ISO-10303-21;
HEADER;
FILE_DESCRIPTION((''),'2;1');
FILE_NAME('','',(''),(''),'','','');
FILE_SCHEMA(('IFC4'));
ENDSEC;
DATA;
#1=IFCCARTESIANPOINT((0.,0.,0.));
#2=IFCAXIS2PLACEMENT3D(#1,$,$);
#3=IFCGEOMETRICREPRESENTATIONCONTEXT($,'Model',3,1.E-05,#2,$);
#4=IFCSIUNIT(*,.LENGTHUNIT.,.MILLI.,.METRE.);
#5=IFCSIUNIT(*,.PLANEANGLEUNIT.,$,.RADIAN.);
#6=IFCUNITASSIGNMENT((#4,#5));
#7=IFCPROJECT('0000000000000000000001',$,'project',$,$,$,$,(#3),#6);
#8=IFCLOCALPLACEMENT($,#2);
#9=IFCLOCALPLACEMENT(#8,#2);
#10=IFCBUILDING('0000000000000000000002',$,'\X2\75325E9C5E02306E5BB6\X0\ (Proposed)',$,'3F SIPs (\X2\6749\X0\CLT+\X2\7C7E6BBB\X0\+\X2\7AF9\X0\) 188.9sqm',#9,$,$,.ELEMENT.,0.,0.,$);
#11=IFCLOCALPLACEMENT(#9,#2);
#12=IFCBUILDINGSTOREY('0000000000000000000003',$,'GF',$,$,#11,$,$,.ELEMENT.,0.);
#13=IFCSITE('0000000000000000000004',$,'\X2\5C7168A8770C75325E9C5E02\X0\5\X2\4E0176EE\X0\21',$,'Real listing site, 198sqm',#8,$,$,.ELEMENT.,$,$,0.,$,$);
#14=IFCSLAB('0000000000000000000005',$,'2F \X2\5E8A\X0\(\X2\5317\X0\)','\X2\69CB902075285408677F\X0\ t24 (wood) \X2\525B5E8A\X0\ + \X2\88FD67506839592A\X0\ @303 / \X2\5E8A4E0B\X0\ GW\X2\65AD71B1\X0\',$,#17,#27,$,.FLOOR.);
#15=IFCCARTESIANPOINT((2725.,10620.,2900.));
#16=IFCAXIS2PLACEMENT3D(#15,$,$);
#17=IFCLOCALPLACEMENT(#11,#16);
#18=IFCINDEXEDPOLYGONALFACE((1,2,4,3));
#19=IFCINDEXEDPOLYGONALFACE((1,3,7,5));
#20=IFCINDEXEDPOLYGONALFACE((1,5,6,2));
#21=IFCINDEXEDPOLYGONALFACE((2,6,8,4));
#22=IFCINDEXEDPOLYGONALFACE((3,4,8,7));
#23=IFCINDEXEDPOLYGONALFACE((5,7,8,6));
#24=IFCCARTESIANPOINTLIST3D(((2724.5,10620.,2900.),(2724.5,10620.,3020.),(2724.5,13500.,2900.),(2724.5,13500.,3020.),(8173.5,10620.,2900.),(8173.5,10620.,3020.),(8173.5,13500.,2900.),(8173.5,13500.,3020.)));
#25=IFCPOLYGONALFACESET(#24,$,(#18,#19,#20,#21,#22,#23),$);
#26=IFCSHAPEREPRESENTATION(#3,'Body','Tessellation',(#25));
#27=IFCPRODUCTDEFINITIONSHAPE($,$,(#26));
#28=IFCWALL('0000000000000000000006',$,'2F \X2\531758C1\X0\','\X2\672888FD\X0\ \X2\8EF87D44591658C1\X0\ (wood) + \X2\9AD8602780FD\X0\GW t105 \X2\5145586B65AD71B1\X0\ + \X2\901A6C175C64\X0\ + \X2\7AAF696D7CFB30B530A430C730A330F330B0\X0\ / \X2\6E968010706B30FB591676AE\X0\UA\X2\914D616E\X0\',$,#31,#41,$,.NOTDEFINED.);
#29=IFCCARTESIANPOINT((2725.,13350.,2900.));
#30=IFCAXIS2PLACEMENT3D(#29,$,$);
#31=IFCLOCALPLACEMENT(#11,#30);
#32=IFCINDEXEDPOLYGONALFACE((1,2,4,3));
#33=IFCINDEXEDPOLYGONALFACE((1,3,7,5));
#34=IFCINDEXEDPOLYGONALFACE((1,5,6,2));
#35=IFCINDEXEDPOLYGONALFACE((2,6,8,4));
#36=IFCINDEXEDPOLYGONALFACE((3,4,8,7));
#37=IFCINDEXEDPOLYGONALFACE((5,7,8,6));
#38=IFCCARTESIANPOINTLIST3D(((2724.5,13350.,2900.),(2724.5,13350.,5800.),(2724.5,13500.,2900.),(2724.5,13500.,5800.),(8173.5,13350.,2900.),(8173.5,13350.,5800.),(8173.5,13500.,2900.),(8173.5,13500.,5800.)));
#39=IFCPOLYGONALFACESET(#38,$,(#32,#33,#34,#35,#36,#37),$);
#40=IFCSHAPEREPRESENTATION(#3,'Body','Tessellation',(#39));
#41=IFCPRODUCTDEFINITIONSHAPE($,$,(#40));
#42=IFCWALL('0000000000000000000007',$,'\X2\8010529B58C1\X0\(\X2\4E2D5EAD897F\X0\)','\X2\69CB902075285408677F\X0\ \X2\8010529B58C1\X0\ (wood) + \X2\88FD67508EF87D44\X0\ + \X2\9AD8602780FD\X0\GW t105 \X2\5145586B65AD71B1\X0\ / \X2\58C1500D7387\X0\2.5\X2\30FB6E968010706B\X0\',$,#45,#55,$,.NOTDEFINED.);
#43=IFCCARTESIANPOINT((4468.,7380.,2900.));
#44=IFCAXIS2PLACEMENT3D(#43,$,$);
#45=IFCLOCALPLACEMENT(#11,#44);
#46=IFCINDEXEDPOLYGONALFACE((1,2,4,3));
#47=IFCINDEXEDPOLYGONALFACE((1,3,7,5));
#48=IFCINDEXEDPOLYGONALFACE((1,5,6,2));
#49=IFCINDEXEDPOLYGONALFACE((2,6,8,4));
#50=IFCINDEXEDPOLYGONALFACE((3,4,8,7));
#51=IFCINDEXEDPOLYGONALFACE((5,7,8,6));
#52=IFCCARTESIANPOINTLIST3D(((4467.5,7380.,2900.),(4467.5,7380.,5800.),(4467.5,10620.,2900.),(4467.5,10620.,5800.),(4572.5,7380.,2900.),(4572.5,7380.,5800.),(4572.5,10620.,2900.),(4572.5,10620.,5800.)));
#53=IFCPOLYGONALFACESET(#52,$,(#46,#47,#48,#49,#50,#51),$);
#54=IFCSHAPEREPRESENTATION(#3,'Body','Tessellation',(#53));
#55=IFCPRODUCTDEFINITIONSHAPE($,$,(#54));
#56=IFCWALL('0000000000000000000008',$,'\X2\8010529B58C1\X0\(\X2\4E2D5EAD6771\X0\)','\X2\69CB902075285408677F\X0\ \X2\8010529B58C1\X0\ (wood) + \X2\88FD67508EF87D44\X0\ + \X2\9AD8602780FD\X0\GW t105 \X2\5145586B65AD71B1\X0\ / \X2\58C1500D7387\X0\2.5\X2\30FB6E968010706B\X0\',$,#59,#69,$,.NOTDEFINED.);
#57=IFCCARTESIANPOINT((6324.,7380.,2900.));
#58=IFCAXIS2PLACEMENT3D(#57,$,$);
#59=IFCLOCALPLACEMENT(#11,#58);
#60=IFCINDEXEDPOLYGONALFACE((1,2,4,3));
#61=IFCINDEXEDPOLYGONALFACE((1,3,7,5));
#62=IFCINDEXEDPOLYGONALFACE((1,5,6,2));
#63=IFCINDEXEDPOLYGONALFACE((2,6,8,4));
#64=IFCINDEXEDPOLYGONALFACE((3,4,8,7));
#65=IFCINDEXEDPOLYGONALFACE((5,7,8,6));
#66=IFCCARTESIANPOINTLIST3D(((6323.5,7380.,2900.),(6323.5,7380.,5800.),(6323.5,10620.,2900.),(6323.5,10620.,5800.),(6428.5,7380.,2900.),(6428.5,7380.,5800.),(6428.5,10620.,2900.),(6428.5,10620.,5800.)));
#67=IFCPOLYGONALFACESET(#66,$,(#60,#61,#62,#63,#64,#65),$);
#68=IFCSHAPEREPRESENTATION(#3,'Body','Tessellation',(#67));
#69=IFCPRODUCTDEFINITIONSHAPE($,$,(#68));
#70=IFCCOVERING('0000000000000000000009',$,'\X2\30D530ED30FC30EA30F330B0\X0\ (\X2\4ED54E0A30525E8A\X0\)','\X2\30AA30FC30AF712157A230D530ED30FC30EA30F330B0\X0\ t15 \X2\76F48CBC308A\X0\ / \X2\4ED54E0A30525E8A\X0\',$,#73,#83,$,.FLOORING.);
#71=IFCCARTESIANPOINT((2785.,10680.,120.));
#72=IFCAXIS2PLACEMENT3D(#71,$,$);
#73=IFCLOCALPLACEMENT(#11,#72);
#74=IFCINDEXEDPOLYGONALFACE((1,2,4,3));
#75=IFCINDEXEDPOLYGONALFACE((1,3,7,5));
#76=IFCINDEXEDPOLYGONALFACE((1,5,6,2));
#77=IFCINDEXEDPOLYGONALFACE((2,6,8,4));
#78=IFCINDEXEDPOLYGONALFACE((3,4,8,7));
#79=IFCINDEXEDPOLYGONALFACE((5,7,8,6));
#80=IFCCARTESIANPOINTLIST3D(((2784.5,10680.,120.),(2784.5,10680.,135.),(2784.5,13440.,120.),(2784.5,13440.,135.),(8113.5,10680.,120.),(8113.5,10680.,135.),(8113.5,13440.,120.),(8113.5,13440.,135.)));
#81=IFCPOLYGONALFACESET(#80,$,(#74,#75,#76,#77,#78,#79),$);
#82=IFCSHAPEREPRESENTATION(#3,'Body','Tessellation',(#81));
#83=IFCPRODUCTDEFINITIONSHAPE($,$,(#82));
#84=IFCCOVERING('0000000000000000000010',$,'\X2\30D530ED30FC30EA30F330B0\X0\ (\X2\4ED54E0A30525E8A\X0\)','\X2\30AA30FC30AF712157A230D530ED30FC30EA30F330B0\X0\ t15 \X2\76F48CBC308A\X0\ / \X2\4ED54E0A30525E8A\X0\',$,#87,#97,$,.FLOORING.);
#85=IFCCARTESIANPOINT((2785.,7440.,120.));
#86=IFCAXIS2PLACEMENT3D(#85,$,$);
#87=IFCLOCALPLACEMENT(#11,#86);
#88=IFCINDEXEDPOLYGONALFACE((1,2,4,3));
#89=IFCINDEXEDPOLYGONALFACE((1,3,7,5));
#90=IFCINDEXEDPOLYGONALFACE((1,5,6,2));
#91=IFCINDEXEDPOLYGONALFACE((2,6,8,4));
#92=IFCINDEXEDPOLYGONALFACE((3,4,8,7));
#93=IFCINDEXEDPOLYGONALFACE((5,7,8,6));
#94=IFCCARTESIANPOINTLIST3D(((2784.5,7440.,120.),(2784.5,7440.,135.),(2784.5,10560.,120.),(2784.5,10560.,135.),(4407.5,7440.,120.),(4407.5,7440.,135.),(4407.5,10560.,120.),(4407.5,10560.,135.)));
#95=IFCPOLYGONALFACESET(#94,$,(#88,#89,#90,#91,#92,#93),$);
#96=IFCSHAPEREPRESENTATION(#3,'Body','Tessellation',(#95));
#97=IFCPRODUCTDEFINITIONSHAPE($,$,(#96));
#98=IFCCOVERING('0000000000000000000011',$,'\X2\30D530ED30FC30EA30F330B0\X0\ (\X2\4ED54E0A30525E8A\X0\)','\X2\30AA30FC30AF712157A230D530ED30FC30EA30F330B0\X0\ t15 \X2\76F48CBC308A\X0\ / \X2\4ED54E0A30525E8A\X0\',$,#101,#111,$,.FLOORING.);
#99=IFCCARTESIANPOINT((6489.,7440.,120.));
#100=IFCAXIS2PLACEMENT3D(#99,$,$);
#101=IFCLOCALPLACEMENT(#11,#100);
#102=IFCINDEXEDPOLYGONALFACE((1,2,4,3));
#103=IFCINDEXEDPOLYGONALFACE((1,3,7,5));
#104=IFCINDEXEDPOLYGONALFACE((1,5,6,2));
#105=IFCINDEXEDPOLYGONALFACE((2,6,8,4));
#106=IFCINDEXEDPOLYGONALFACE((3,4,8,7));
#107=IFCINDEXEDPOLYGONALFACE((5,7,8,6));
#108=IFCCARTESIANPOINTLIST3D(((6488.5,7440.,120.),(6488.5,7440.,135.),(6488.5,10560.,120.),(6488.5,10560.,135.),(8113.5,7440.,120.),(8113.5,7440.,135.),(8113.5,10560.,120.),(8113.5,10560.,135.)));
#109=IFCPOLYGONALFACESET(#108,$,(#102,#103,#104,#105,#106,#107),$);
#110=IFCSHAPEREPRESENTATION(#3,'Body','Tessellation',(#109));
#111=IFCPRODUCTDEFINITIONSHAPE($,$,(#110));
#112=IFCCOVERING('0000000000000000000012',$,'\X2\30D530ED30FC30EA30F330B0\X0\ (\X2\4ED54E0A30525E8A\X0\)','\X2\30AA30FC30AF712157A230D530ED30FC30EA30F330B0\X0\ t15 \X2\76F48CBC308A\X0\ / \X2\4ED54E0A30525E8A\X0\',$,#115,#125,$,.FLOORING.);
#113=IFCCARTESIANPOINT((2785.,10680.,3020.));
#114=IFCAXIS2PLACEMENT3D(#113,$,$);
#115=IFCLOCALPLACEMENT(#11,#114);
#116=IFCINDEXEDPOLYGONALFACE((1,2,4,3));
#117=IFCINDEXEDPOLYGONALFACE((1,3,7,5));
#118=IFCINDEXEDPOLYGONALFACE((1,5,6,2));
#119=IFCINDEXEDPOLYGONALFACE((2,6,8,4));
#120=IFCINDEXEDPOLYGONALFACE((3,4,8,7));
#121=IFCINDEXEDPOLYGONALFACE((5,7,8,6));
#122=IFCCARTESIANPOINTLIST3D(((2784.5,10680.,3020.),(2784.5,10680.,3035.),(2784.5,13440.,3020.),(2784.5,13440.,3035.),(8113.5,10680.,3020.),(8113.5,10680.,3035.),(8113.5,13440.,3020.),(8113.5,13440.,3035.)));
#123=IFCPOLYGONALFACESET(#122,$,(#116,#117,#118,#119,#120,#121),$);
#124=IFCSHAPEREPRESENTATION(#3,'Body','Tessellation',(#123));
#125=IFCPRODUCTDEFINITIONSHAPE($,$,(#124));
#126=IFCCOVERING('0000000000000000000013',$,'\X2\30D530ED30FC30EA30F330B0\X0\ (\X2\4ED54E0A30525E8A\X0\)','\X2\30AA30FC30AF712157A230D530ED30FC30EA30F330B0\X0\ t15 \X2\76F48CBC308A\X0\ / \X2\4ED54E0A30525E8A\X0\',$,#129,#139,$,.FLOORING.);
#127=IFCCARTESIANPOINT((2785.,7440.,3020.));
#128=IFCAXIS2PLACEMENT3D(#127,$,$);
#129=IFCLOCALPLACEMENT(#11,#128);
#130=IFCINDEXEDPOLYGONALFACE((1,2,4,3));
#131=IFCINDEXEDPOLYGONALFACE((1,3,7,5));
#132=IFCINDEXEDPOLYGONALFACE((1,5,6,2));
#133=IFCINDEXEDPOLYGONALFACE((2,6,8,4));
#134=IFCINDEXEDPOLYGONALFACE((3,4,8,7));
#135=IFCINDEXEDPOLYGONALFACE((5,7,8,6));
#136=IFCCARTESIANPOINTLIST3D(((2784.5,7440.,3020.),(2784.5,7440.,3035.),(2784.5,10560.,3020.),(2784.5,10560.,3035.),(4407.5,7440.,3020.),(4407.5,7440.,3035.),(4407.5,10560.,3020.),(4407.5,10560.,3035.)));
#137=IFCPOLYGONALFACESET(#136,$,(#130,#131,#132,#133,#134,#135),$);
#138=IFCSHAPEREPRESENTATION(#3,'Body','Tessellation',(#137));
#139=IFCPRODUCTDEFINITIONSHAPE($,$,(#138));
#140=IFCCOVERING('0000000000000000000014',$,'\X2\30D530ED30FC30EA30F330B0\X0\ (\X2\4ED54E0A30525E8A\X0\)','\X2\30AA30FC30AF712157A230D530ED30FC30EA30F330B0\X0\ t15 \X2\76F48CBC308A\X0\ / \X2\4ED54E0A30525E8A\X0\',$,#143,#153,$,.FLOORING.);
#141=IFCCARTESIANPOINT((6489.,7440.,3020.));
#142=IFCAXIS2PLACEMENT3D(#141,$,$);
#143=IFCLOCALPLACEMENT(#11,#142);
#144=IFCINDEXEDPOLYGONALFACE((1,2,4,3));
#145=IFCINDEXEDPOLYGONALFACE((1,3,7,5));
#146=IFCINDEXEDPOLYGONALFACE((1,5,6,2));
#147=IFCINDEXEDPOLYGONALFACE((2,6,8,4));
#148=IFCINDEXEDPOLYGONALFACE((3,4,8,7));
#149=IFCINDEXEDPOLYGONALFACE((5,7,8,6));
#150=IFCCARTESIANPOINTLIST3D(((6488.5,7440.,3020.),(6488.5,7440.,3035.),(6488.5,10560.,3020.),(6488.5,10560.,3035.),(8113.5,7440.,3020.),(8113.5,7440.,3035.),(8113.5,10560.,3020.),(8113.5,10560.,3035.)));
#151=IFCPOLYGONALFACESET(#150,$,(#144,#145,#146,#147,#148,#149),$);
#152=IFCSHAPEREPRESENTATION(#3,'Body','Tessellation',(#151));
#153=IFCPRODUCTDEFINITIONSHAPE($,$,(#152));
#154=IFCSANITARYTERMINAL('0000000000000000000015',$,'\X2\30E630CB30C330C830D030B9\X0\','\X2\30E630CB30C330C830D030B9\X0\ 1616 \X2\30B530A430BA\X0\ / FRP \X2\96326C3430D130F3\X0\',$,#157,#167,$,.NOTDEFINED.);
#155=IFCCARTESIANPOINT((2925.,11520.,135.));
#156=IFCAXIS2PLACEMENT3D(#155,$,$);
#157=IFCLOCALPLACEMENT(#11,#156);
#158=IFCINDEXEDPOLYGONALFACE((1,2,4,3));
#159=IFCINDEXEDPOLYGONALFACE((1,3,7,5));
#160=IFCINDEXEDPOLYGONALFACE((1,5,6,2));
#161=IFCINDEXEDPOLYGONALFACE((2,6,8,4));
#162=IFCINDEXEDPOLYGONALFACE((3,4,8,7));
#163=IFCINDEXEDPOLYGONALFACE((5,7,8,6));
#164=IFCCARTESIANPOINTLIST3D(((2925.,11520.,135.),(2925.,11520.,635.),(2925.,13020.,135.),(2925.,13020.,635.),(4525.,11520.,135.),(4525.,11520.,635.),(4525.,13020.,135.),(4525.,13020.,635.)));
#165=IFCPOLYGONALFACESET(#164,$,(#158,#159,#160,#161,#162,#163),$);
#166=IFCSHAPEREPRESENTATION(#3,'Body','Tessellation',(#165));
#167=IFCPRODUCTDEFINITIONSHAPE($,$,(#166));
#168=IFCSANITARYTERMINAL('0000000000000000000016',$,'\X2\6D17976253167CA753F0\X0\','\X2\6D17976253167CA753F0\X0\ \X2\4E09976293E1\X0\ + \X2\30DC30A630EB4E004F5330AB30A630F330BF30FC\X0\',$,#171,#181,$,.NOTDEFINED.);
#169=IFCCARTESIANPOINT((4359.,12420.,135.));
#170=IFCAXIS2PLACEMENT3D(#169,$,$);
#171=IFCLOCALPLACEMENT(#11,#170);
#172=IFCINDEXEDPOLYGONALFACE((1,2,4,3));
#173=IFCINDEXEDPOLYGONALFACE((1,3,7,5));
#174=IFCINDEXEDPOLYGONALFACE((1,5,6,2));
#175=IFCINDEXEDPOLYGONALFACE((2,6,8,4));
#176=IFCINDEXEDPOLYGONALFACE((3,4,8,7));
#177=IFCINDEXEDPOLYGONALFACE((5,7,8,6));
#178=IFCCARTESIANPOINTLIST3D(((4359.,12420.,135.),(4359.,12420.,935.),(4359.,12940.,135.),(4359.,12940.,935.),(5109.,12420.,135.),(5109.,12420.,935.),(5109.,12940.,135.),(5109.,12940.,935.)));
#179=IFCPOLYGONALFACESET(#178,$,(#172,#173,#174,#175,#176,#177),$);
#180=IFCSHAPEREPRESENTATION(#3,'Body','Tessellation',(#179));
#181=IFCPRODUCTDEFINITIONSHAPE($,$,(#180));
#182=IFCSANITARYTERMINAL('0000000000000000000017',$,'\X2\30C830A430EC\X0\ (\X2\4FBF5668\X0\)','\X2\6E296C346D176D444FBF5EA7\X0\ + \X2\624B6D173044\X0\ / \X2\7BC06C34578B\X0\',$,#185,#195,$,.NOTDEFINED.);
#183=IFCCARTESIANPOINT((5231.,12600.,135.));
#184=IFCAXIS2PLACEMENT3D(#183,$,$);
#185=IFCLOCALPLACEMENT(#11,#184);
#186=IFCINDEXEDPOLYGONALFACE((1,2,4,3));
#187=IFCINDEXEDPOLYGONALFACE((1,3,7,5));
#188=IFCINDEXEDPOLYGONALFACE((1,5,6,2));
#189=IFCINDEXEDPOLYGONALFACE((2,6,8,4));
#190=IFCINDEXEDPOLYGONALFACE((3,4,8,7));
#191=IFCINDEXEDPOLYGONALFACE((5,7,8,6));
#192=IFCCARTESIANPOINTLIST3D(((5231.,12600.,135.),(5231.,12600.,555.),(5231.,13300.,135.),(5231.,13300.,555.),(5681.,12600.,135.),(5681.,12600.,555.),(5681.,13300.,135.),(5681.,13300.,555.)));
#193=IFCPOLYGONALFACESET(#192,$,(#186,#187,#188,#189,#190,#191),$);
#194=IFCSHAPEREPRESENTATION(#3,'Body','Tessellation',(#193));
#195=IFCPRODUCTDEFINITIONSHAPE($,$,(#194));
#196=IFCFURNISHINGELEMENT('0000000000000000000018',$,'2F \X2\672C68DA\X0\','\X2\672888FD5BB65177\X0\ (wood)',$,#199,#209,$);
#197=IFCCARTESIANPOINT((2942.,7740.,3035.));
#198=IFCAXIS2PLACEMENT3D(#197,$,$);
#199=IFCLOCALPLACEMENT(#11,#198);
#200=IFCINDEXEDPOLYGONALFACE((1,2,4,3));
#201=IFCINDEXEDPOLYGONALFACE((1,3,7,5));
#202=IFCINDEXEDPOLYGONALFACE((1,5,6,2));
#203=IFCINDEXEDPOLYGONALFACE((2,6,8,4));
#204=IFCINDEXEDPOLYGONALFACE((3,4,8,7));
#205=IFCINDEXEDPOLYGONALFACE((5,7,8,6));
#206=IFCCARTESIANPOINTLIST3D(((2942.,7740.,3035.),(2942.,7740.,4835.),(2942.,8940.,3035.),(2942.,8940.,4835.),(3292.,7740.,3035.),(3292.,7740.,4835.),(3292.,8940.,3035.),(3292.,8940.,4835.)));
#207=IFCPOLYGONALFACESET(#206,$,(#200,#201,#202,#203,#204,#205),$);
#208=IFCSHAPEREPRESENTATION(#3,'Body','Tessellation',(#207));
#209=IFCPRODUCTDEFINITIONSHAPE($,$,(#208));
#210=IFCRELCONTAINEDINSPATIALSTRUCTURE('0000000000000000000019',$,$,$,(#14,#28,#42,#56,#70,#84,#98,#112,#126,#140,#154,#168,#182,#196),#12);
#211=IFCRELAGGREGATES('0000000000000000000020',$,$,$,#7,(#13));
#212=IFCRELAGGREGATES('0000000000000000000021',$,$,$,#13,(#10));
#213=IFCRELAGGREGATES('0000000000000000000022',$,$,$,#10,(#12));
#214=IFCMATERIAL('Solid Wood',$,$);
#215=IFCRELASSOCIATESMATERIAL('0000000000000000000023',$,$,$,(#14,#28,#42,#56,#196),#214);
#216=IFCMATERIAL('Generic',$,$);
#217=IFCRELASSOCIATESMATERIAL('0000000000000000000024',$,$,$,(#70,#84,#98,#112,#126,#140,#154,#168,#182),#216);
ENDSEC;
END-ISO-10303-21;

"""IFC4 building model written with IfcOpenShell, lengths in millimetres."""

from ifc_helpers import new_model, si_unit, frame, frame_2d, origin, place, context, project, spatial, rectangle, extrude, material, element, save


model = new_model("IFC4")

# Units and contexts
model_context = context("Model", 3, precision=1e-05, world=origin())
ifc_project = project(units=[si_unit("LENGTHUNIT", "METRE", prefix="MILLI"), si_unit("PLANEANGLEUNIT", "RADIAN")], contexts=[model_context])

# Site, building, storey
site_placement = place(None, origin())
site = spatial("IfcSite", under=ifc_project, at=site_placement, Name="山梨県甲府市5丁目21", ObjectType="Real listing site, 198sqm", CompositionType="ELEMENT", RefElevation=0.0)
building_placement = place(site_placement, origin())
building = spatial("IfcBuilding", under=site, at=building_placement, Name="甲府市の家 (Proposed)", ObjectType="3F SIPs (杉CLT+籾殻+竹) 188.9sqm", CompositionType="ELEMENT", ElevationOfRefHeight=0.0, ElevationOfTerrain=0.0)
storey_placement = place(building_placement, origin())
storey = spatial("IfcBuildingStorey", under=building, at=storey_placement, Name="GF", CompositionType="ELEMENT", Elevation=0.0)

# Slab
ifc_material_1 = material(Name="Solid Wood")
slab_1_placement = place(storey_placement, frame((2725.0, 10620.0, 2900.0)))
element("IfcSlab", 1, at=slab_1_placement, inside=storey, material=ifc_material_1, Name="2F 床(北)", Description="構造用合板 t24 (wood) 剛床 + 製材根太 @303 / 床下 GW断熱", PredefinedType="FLOOR", context=model_context, shape_type="SweptSolid", body=[
    extrude(rectangle(XDim=5449.0, YDim=2880.0, at=frame_2d((2724.0, 1440.0))), frame((2725.0, 10620.0, 2900.0)), (0.0, 0.0, 1.0), 120.0),
])

# Wall
wall_1_placement = place(storey_placement, frame((2725.0, 13350.0, 2900.0)))
element("IfcWall", 2, at=wall_1_placement, inside=storey, material=ifc_material_1, Name="2F 北壁", Description="木製 軸組外壁 (wood) + 高性能GW t105 充填断熱 + 通気層 + 窯業系サイディング / 準耐火・外皮UA配慮", PredefinedType="NOTDEFINED", context=model_context, shape_type="SweptSolid", body=[
    extrude(rectangle(XDim=5449.0, YDim=150.0, at=frame_2d((2724.0, 75.0))), frame((2725.0, 13350.0, 2900.0)), (0.0, 0.0, 1.0), 2900.0),
])

# Walls
wall_2_placement = place(storey_placement, frame((4468.0, 7380.0, 2900.0)))
element("IfcWall", 3, at=wall_2_placement, inside=storey, material=ifc_material_1, Name="耐力壁(中庭西)", Description="構造用合板 耐力壁 (wood) + 製材軸組 + 高性能GW t105 充填断熱 / 壁倍率2.5・準耐火", PredefinedType="NOTDEFINED", context=model_context, shape_type="SweptSolid", body=[
    extrude(rectangle(XDim=105.0, YDim=3240.0, at=frame_2d((52.0, 1620.0))), frame((4468.0, 7380.0, 2900.0)), (0.0, 0.0, 1.0), 2900.0),
])
wall_3_placement = place(storey_placement, frame((6324.0, 7380.0, 2900.0)))
element("IfcWall", 4, at=wall_3_placement, inside=storey, material=ifc_material_1, Name="耐力壁(中庭東)", Description="構造用合板 耐力壁 (wood) + 製材軸組 + 高性能GW t105 充填断熱 / 壁倍率2.5・準耐火", PredefinedType="NOTDEFINED", context=model_context, shape_type="SweptSolid", body=[
    extrude(rectangle(XDim=105.0, YDim=3240.0, at=frame_2d((52.0, 1620.0))), frame((6324.0, 7380.0, 2900.0)), (0.0, 0.0, 1.0), 2900.0),
])

# Coverings
ifc_material_2 = material(Name="Generic")
covering_1_placement = place(storey_placement, frame((2785.0, 10680.0, 120.0)))
element("IfcCovering", 5, at=covering_1_placement, inside=storey, material=ifc_material_2, Name="フローリング (仕上げ床)", Description="オーク無垢フローリング t15 直貼り / 仕上げ床", PredefinedType="FLOORING", context=model_context, shape_type="SweptSolid", body=[
    extrude(rectangle(XDim=5329.0, YDim=2760.0, at=frame_2d((2664.0, 1380.0))), frame((2785.0, 10680.0, 120.0)), (0.0, 0.0, 1.0), 15.0),
])
covering_2_placement = place(storey_placement, frame((2785.0, 7440.0, 120.0)))
element("IfcCovering", 6, at=covering_2_placement, inside=storey, material=ifc_material_2, Name="フローリング (仕上げ床)", Description="オーク無垢フローリング t15 直貼り / 仕上げ床", PredefinedType="FLOORING", context=model_context, shape_type="SweptSolid", body=[
    extrude(rectangle(XDim=1623.0, YDim=3120.0, at=frame_2d((811.0, 1560.0))), frame((2785.0, 7440.0, 120.0)), (0.0, 0.0, 1.0), 15.0),
])
covering_3_placement = place(storey_placement, frame((6489.0, 7440.0, 120.0)))
element("IfcCovering", 7, at=covering_3_placement, inside=storey, material=ifc_material_2, Name="フローリング (仕上げ床)", Description="オーク無垢フローリング t15 直貼り / 仕上げ床", PredefinedType="FLOORING", context=model_context, shape_type="SweptSolid", body=[
    extrude(rectangle(XDim=1625.0, YDim=3120.0, at=frame_2d((812.0, 1560.0))), frame((6489.0, 7440.0, 120.0)), (0.0, 0.0, 1.0), 15.0),
])
covering_4_placement = place(storey_placement, frame((2785.0, 10680.0, 3020.0)))
element("IfcCovering", 8, at=covering_4_placement, inside=storey, material=ifc_material_2, Name="フローリング (仕上げ床)", Description="オーク無垢フローリング t15 直貼り / 仕上げ床", PredefinedType="FLOORING", context=model_context, shape_type="SweptSolid", body=[
    extrude(rectangle(XDim=5329.0, YDim=2760.0, at=frame_2d((2664.0, 1380.0))), frame((2785.0, 10680.0, 3020.0)), (0.0, 0.0, 1.0), 15.0),
])
covering_5_placement = place(storey_placement, frame((2785.0, 7440.0, 3020.0)))
element("IfcCovering", 9, at=covering_5_placement, inside=storey, material=ifc_material_2, Name="フローリング (仕上げ床)", Description="オーク無垢フローリング t15 直貼り / 仕上げ床", PredefinedType="FLOORING", context=model_context, shape_type="SweptSolid", body=[
    extrude(rectangle(XDim=1623.0, YDim=3120.0, at=frame_2d((811.0, 1560.0))), frame((2785.0, 7440.0, 3020.0)), (0.0, 0.0, 1.0), 15.0),
])
covering_6_placement = place(storey_placement, frame((6489.0, 7440.0, 3020.0)))
element("IfcCovering", 10, at=covering_6_placement, inside=storey, material=ifc_material_2, Name="フローリング (仕上げ床)", Description="オーク無垢フローリング t15 直貼り / 仕上げ床", PredefinedType="FLOORING", context=model_context, shape_type="SweptSolid", body=[
    extrude(rectangle(XDim=1625.0, YDim=3120.0, at=frame_2d((812.0, 1560.0))), frame((6489.0, 7440.0, 3020.0)), (0.0, 0.0, 1.0), 15.0),
])

# Sanitary terminals
sanitary_terminal_1_placement = place(storey_placement, frame((2925.0, 11520.0, 135.0)))
element("IfcSanitaryTerminal", 11, at=sanitary_terminal_1_placement, inside=storey, material=ifc_material_2, Name="ユニットバス", Description="ユニットバス 1616 サイズ / FRP 防水パン", PredefinedType="NOTDEFINED", context=model_context, shape_type="SweptSolid", body=[
    extrude(rectangle(XDim=1600.0, YDim=1500.0, at=frame_2d((800.0, 750.0))), frame((2925.0, 11520.0, 135.0)), (0.0, 0.0, 1.0), 500.0),
])
sanitary_terminal_2_placement = place(storey_placement, frame((4359.0, 12420.0, 135.0)))
element("IfcSanitaryTerminal", 12, at=sanitary_terminal_2_placement, inside=storey, material=ifc_material_2, Name="洗面化粧台", Description="洗面化粧台 三面鏡 + ボウル一体カウンター", PredefinedType="NOTDEFINED", context=model_context, shape_type="SweptSolid", body=[
    extrude(rectangle(XDim=750.0, YDim=520.0, at=frame_2d((375.0, 260.0))), frame((4359.0, 12420.0, 135.0)), (0.0, 0.0, 1.0), 800.0),
])
sanitary_terminal_3_placement = place(storey_placement, frame((5231.0, 12600.0, 135.0)))
element("IfcSanitaryTerminal", 13, at=sanitary_terminal_3_placement, inside=storey, material=ifc_material_2, Name="トイレ (便器)", Description="温水洗浄便座 + 手洗い / 節水型", PredefinedType="NOTDEFINED", context=model_context, shape_type="SweptSolid", body=[
    extrude(rectangle(XDim=450.0, YDim=700.0, at=frame_2d((225.0, 350.0))), frame((5231.0, 12600.0, 135.0)), (0.0, 0.0, 1.0), 420.0),
])

# Furnishing element
furnishing_placement = place(storey_placement, frame((2942.0, 7740.0, 3035.0)))
element("IfcFurnishingElement", 14, at=furnishing_placement, inside=storey, material=ifc_material_1, Name="2F 本棚", Description="木製家具 (wood)", context=model_context, shape_type="SweptSolid", body=[
    extrude(rectangle(XDim=350.0, YDim=1200.0, at=frame_2d((175.0, 600.0))), frame((2942.0, 7740.0, 3035.0)), (0.0, 0.0, 1.0), 1800.0),
])

save(model, "model.ifc")
